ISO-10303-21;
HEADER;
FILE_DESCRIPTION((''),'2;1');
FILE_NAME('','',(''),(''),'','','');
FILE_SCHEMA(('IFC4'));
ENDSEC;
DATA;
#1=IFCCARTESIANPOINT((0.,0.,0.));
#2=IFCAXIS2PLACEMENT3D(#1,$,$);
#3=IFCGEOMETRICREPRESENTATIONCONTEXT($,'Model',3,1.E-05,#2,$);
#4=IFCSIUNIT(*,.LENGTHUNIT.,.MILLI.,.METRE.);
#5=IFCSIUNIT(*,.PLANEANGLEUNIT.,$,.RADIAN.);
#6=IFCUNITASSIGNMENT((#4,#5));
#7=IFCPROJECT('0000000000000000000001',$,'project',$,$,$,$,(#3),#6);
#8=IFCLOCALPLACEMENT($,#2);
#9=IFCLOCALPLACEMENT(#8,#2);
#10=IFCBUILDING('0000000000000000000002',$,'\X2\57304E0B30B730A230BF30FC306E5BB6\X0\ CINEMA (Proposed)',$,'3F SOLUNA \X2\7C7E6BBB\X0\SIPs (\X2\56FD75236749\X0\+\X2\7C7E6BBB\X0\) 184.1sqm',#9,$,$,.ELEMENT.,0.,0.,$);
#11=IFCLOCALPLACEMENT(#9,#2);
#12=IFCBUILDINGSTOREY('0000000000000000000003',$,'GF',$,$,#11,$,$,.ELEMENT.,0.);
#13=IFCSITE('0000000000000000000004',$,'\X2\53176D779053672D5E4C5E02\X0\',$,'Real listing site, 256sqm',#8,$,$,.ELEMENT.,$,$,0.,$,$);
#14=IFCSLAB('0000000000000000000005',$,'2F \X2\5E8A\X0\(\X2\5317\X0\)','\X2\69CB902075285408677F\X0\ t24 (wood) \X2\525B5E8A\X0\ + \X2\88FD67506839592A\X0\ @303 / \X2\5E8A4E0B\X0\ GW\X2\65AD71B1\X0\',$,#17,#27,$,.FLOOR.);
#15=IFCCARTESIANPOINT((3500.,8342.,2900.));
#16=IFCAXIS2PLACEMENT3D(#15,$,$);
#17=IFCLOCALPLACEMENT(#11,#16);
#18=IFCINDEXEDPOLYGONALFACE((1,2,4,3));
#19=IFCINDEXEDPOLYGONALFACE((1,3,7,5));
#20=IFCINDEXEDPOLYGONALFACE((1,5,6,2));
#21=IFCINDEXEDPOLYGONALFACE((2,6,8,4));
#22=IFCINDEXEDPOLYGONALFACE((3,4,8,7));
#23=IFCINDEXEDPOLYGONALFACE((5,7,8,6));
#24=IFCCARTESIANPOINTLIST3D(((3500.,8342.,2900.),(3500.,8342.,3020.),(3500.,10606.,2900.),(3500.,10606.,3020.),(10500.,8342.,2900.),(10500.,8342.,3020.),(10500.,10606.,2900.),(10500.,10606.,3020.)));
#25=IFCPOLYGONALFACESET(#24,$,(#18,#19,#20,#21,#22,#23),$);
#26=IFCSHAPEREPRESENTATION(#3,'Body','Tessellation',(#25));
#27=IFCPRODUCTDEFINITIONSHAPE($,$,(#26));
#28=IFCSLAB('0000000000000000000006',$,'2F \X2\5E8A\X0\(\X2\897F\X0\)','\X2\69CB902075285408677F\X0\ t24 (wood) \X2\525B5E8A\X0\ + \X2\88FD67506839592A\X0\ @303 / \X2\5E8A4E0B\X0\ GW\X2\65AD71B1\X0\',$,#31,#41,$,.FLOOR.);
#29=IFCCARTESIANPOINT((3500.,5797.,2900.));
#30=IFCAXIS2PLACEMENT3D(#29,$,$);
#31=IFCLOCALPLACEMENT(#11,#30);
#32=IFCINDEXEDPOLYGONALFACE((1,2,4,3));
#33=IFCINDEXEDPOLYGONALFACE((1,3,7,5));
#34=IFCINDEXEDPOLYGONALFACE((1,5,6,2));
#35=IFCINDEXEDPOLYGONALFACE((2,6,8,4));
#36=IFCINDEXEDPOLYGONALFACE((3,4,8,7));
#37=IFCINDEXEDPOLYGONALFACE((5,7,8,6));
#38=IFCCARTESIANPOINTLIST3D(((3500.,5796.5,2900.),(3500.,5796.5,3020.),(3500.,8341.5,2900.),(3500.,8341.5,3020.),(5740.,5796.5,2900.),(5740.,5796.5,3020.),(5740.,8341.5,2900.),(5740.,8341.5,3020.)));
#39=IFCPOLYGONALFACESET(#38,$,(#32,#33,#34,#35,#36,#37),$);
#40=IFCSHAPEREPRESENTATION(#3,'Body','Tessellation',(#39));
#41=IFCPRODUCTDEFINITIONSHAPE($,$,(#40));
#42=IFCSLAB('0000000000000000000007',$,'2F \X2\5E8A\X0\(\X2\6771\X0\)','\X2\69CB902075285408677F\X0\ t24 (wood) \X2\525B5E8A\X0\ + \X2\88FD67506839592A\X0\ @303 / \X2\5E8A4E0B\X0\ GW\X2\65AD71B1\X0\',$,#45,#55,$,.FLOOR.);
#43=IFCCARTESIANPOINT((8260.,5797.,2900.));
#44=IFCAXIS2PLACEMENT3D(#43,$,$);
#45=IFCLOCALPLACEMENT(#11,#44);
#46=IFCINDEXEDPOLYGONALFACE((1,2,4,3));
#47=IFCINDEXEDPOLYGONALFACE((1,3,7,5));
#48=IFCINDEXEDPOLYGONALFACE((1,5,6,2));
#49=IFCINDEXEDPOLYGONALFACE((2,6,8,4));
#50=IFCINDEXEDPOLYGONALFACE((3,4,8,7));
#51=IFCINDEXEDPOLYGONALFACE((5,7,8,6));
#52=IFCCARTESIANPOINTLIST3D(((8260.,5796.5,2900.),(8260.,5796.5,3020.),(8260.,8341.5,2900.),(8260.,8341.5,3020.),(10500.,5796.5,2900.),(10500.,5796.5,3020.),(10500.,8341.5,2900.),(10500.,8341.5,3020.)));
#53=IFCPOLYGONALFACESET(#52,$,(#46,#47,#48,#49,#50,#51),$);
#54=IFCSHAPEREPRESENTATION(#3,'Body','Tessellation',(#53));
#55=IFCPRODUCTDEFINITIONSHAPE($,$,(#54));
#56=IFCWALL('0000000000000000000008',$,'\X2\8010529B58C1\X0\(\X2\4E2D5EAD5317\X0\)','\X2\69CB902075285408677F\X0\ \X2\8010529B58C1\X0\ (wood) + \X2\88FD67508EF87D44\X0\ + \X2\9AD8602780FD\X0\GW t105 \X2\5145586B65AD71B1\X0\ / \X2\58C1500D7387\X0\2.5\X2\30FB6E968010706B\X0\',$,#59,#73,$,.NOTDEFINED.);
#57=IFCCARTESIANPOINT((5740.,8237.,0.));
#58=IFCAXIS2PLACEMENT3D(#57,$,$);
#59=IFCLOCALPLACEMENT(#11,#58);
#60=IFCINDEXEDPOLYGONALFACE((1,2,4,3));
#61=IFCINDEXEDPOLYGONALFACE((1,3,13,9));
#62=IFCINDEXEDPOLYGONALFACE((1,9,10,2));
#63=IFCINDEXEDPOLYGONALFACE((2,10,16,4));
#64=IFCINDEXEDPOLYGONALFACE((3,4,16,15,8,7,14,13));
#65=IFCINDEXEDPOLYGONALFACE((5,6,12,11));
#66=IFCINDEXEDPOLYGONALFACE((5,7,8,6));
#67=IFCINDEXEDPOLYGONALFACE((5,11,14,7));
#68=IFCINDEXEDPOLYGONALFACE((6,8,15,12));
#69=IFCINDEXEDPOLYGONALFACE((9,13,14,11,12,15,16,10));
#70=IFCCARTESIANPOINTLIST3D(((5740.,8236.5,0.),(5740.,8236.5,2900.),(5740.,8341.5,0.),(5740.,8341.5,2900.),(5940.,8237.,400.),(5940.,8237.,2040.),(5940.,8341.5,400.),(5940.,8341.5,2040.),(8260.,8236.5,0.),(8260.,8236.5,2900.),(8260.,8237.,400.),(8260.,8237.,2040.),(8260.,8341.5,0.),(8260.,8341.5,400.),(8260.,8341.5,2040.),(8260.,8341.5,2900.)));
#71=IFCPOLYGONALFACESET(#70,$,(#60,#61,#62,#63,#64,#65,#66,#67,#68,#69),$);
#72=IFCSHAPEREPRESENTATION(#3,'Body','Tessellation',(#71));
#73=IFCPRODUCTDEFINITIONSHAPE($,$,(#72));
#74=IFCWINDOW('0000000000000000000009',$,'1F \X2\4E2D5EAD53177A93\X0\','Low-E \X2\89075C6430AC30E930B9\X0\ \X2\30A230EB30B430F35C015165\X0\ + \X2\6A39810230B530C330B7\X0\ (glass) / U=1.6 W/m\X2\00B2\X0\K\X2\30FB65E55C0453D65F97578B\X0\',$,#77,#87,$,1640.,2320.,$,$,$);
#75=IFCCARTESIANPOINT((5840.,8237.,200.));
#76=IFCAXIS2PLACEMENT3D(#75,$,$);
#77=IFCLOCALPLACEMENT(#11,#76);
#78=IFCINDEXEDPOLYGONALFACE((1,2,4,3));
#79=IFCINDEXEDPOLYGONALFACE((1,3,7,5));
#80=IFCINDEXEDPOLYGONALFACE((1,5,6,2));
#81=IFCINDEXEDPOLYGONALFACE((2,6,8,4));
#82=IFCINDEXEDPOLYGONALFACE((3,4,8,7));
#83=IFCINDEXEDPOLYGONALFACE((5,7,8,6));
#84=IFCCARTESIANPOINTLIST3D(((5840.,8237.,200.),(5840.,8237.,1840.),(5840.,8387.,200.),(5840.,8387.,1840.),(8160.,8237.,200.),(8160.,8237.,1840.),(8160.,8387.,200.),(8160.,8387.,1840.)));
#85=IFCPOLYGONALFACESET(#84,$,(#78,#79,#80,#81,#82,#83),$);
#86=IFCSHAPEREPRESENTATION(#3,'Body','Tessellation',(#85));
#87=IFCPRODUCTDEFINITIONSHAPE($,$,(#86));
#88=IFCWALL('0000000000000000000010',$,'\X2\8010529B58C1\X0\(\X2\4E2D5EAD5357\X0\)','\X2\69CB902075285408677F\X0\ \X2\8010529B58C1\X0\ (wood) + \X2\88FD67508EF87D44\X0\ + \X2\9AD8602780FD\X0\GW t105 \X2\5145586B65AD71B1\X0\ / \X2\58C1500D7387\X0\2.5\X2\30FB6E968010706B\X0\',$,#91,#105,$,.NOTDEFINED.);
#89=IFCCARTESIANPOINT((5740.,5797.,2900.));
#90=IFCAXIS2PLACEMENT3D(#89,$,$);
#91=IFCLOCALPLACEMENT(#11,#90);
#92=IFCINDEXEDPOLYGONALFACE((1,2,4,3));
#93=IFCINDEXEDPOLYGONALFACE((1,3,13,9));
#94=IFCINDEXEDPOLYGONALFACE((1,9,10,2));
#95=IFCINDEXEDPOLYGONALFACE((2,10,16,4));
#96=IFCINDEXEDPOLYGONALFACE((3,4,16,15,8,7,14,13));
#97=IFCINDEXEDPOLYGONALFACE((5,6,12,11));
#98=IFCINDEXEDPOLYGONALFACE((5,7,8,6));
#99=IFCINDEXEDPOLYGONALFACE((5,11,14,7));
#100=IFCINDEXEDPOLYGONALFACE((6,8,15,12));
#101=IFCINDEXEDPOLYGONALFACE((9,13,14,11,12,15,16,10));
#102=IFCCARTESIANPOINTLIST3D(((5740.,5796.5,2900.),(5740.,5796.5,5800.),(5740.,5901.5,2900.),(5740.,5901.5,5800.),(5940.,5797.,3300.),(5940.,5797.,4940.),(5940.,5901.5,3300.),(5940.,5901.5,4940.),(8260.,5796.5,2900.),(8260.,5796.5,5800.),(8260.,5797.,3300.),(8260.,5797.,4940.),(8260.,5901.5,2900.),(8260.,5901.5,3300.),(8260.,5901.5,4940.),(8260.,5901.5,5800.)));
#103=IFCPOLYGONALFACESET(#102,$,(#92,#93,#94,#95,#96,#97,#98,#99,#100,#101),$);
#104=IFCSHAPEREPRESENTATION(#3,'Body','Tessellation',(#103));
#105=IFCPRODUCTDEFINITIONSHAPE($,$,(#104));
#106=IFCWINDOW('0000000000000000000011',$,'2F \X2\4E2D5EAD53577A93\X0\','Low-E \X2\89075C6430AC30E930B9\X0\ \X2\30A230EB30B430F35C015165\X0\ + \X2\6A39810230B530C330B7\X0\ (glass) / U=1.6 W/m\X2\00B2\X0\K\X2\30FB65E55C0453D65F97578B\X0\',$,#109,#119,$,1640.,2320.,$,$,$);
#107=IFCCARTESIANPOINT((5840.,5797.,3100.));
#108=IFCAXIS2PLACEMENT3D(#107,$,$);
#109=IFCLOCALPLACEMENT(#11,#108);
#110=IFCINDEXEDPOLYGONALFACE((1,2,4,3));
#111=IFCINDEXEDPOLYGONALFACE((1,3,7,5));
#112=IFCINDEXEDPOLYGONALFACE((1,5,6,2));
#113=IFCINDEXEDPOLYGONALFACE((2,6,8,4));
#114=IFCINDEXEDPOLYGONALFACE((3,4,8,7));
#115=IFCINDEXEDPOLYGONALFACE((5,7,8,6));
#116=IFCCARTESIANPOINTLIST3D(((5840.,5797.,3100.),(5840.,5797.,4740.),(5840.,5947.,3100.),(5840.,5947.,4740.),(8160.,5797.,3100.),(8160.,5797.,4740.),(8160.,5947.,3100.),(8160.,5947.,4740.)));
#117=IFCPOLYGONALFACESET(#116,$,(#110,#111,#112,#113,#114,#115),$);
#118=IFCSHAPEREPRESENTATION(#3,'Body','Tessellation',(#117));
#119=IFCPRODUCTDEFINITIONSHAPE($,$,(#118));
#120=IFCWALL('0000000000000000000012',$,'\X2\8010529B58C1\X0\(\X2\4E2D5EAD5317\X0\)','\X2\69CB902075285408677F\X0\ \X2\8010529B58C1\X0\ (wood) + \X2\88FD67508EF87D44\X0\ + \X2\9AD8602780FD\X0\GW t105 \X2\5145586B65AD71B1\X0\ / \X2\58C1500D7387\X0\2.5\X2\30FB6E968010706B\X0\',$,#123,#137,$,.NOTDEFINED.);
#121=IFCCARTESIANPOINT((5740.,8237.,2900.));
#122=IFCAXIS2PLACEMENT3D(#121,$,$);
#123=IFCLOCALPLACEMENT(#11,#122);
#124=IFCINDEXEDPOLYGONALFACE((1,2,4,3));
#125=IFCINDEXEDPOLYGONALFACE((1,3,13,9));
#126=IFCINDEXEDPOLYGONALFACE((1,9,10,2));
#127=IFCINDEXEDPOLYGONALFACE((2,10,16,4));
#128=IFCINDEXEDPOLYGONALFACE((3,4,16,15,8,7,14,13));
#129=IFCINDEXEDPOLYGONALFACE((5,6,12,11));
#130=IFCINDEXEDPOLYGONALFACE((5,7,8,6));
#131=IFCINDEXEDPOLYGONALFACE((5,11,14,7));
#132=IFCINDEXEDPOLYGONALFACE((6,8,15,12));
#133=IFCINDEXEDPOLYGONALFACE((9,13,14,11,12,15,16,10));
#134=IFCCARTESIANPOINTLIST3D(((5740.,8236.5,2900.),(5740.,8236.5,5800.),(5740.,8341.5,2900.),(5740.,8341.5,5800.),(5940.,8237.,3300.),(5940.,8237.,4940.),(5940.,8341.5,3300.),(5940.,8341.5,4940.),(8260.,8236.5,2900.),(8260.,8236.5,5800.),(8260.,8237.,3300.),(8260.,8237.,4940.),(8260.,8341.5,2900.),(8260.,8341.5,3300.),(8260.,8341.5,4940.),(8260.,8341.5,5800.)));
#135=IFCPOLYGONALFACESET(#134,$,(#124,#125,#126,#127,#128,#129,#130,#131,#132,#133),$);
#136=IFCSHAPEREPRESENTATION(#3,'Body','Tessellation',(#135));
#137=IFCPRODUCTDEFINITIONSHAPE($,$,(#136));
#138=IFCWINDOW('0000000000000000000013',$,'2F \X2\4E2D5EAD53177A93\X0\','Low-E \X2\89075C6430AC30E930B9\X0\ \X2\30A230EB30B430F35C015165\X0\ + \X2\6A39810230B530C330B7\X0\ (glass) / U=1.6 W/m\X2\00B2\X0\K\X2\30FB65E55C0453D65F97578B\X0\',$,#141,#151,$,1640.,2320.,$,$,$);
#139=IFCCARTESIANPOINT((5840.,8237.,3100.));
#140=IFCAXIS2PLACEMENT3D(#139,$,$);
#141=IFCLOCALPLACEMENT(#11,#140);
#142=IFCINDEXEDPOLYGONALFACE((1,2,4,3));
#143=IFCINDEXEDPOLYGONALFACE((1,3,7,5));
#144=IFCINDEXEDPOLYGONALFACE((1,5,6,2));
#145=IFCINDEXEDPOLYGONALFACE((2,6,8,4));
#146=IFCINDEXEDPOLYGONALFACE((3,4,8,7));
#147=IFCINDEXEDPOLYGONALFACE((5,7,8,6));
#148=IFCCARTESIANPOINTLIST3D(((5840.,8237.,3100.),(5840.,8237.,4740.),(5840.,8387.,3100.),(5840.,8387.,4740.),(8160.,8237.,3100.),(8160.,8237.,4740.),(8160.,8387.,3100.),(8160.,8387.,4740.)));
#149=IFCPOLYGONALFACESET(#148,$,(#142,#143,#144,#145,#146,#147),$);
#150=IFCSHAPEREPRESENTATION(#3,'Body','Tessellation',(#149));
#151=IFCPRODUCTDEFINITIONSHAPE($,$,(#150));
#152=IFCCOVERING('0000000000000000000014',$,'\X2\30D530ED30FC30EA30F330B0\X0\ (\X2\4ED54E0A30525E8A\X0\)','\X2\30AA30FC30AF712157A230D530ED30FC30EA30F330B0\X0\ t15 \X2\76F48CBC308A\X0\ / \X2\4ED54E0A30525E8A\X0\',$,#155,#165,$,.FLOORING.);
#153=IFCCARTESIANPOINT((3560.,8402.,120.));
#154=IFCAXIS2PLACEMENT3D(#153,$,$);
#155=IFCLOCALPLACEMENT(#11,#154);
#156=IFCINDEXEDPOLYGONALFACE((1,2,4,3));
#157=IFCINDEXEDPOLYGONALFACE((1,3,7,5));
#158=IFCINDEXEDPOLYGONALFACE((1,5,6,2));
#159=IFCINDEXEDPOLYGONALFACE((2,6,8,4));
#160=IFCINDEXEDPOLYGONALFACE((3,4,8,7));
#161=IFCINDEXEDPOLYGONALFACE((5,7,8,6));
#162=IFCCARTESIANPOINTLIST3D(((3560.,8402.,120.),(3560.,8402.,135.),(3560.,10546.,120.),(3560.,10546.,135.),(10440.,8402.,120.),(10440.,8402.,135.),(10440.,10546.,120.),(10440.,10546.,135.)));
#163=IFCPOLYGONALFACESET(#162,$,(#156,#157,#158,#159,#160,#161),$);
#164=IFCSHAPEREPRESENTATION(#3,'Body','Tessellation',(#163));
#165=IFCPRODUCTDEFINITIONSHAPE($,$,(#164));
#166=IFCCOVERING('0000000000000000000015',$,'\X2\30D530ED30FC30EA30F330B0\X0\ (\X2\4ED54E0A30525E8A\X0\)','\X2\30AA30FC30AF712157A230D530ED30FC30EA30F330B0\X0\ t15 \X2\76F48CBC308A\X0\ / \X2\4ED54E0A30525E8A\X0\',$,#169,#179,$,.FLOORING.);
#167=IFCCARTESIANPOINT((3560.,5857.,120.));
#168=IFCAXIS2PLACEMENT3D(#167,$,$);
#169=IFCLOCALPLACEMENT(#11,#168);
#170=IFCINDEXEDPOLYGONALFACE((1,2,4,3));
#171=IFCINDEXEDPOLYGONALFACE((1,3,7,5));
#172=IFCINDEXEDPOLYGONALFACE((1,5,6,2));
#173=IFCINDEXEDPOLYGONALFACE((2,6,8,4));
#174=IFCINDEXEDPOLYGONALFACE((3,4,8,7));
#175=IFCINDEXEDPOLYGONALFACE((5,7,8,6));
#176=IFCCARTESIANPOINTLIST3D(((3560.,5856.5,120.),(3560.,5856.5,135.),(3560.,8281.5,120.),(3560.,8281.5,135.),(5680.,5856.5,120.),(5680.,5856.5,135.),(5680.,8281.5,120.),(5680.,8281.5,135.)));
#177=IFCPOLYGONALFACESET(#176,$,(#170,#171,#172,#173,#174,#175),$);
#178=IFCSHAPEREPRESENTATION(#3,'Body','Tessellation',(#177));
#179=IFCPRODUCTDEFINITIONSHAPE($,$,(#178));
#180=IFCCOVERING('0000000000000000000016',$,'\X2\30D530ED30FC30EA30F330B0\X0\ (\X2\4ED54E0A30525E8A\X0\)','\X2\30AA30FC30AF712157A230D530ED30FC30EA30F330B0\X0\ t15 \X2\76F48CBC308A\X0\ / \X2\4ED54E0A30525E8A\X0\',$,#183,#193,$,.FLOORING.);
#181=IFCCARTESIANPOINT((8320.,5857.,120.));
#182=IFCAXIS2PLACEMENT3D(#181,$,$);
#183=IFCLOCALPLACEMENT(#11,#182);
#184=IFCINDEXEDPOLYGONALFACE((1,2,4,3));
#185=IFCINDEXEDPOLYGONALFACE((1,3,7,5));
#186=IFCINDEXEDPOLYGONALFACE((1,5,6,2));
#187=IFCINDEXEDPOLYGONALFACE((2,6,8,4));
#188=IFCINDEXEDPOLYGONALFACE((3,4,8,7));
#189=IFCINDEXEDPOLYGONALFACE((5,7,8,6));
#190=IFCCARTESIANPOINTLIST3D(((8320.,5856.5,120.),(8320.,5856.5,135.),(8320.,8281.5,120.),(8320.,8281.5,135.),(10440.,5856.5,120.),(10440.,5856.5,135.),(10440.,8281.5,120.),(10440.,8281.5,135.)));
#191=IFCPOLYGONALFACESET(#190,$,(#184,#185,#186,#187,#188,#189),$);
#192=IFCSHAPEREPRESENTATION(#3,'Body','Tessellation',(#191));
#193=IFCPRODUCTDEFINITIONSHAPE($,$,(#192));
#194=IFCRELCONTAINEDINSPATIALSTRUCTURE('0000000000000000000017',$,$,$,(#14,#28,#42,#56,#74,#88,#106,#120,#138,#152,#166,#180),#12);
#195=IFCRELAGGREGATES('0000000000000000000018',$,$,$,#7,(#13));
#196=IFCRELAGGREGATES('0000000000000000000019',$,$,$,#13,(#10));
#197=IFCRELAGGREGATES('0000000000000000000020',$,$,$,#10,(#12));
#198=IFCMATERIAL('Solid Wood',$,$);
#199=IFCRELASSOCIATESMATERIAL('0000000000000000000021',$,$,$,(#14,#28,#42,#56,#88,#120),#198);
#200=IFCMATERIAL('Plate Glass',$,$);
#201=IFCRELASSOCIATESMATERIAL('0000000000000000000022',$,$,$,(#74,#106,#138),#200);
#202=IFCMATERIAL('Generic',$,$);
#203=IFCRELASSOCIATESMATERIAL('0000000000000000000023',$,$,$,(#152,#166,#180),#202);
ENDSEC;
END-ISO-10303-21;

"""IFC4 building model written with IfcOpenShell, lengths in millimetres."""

from ifc_helpers import new_model, si_unit, frame, frame_2d, origin, place, context, project, spatial, rectangle, extrude, material, element, fill, save


model = new_model("IFC4")

# Units and contexts
model_context = context("Model", 3, precision=1e-05, world=origin())
ifc_project = project(units=[si_unit("LENGTHUNIT", "METRE", prefix="MILLI"), si_unit("PLANEANGLEUNIT", "RADIAN")], contexts=[model_context])

# Site, building, storey
site_placement = place(None, origin())
site = spatial("IfcSite", under=ifc_project, at=site_placement, Name="北海道札幌市", ObjectType="Real listing site, 256sqm", CompositionType="ELEMENT", RefElevation=0.0)
building_placement = place(site_placement, origin())
building = spatial("IfcBuilding", under=site, at=building_placement, Name="地下シアターの家 CINEMA (Proposed)", ObjectType="3F SOLUNA 籾殻SIPs (国産杉+籾殻) 184.1sqm", CompositionType="ELEMENT", ElevationOfRefHeight=0.0, ElevationOfTerrain=0.0)
storey_placement = place(building_placement, origin())
storey = spatial("IfcBuildingStorey", under=building, at=storey_placement, Name="GF", CompositionType="ELEMENT", Elevation=0.0)

# Slabs
ifc_material_1 = material(Name="Solid Wood")
slab_1_placement = place(storey_placement, frame((3500.0, 8342.0, 2900.0)))
element("IfcSlab", 1, at=slab_1_placement, inside=storey, material=ifc_material_1, Name="2F 床(北)", Description="構造用合板 t24 (wood) 剛床 + 製材根太 @303 / 床下 GW断熱", PredefinedType="FLOOR", context=model_context, shape_type="SweptSolid", body=[
    extrude(rectangle(XDim=7000.0, YDim=2264.0, at=frame_2d((3500.0, 1132.0))), frame((3500.0, 8342.0, 2900.0)), (0.0, 0.0, 1.0), 120.0),
])
slab_2_placement = place(storey_placement, frame((3500.0, 5797.0, 2900.0)))
element("IfcSlab", 2, at=slab_2_placement, inside=storey, material=ifc_material_1, Name="2F 床(西)", Description="構造用合板 t24 (wood) 剛床 + 製材根太 @303 / 床下 GW断熱", PredefinedType="FLOOR", context=model_context, shape_type="SweptSolid", body=[
    extrude(rectangle(XDim=2240.0, YDim=2545.0, at=frame_2d((1120.0, 1272.0))), frame((3500.0, 5797.0, 2900.0)), (0.0, 0.0, 1.0), 120.0),
])
slab_3_placement = place(storey_placement, frame((8260.0, 5797.0, 2900.0)))
element("IfcSlab", 3, at=slab_3_placement, inside=storey, material=ifc_material_1, Name="2F 床(東)", Description="構造用合板 t24 (wood) 剛床 + 製材根太 @303 / 床下 GW断熱", PredefinedType="FLOOR", context=model_context, shape_type="SweptSolid", body=[
    extrude(rectangle(XDim=2240.0, YDim=2545.0, at=frame_2d((1120.0, 1272.0))), frame((8260.0, 5797.0, 2900.0)), (0.0, 0.0, 1.0), 120.0),
])

# Wall, opening, window
wall_1_placement = place(storey_placement, frame((5740.0, 8237.0, 0.0)))
wall_1 = element("IfcWall", 4, at=wall_1_placement, inside=storey, material=ifc_material_1, Name="耐力壁(中庭北)", Description="構造用合板 耐力壁 (wood) + 製材軸組 + 高性能GW t105 充填断熱 / 壁倍率2.5・準耐火", PredefinedType="NOTDEFINED", context=model_context, shape_type="SweptSolid", body=[
    extrude(rectangle(XDim=2520.0, YDim=105.0, at=frame_2d((1260.0, 52.0))), frame((5740.0, 8237.0, 0.0)), (0.0, 0.0, 1.0), 2900.0),
])
opening_1_placement = place(storey_placement, frame((5840.0, 8237.0, 200.0)))
opening_1 = element("IfcOpeningElement", 5, at=opening_1_placement, cuts=wall_1, PredefinedType="NOTDEFINED", context=model_context, shape_type="SweptSolid", body=[
    extrude(rectangle(XDim=2320.0, YDim=150.0, at=frame_2d((1160.0, 75.0))), frame((5840.0, 8237.0, 200.0)), (0.0, 0.0, 1.0), 1640.0),
])
ifc_material_2 = material(Name="Plate Glass")
window_1_placement = place(storey_placement, frame((5840.0, 8237.0, 200.0)))
window_1 = element("IfcWindow", 6, at=window_1_placement, inside=storey, material=ifc_material_2, Name="1F 中庭北窓", Description="Low-E 複層ガラス アルゴン封入 + 樹脂サッシ (glass) / U=1.6 W/m²K・日射取得型", OverallHeight=1640.0, OverallWidth=2320.0, context=model_context, shape_type="SweptSolid", body=[
    extrude(rectangle(XDim=2320.0, YDim=150.0, at=frame_2d((1160.0, 75.0))), frame((5840.0, 8237.0, 200.0)), (0.0, 0.0, 1.0), 1640.0),
])
fill(opening_1, window_1)

# Walls, openings, windows
wall_2_placement = place(storey_placement, frame((5740.0, 5797.0, 2900.0)))
wall_2 = element("IfcWall", 7, at=wall_2_placement, inside=storey, material=ifc_material_1, Name="耐力壁(中庭南)", Description="構造用合板 耐力壁 (wood) + 製材軸組 + 高性能GW t105 充填断熱 / 壁倍率2.5・準耐火", PredefinedType="NOTDEFINED", context=model_context, shape_type="SweptSolid", body=[
    extrude(rectangle(XDim=2520.0, YDim=105.0, at=frame_2d((1260.0, 52.0))), frame((5740.0, 5797.0, 2900.0)), (0.0, 0.0, 1.0), 2900.0),
])
opening_2_placement = place(storey_placement, frame((5840.0, 5797.0, 3100.0)))
opening_2 = element("IfcOpeningElement", 8, at=opening_2_placement, cuts=wall_2, PredefinedType="NOTDEFINED", context=model_context, shape_type="SweptSolid", body=[
    extrude(rectangle(XDim=2320.0, YDim=150.0, at=frame_2d((1160.0, 75.0))), frame((5840.0, 5797.0, 3100.0)), (0.0, 0.0, 1.0), 1640.0),
])
window_2_placement = place(storey_placement, frame((5840.0, 5797.0, 3100.0)))
window_2 = element("IfcWindow", 9, at=window_2_placement, inside=storey, material=ifc_material_2, Name="2F 中庭南窓", Description="Low-E 複層ガラス アルゴン封入 + 樹脂サッシ (glass) / U=1.6 W/m²K・日射取得型", OverallHeight=1640.0, OverallWidth=2320.0, context=model_context, shape_type="SweptSolid", body=[
    extrude(rectangle(XDim=2320.0, YDim=150.0, at=frame_2d((1160.0, 75.0))), frame((5840.0, 5797.0, 3100.0)), (0.0, 0.0, 1.0), 1640.0),
])
fill(opening_2, window_2)
wall_3_placement = place(storey_placement, frame((5740.0, 8237.0, 2900.0)))
wall_3 = element("IfcWall", 10, at=wall_3_placement, inside=storey, material=ifc_material_1, Name="耐力壁(中庭北)", Description="構造用合板 耐力壁 (wood) + 製材軸組 + 高性能GW t105 充填断熱 / 壁倍率2.5・準耐火", PredefinedType="NOTDEFINED", context=model_context, shape_type="SweptSolid", body=[
    extrude(rectangle(XDim=2520.0, YDim=105.0, at=frame_2d((1260.0, 52.0))), frame((5740.0, 8237.0, 2900.0)), (0.0, 0.0, 1.0), 2900.0),
])
opening_3_placement = place(storey_placement, frame((5840.0, 8237.0, 3100.0)))
opening_3 = element("IfcOpeningElement", 11, at=opening_3_placement, cuts=wall_3, PredefinedType="NOTDEFINED", context=model_context, shape_type="SweptSolid", body=[
    extrude(rectangle(XDim=2320.0, YDim=150.0, at=frame_2d((1160.0, 75.0))), frame((5840.0, 8237.0, 3100.0)), (0.0, 0.0, 1.0), 1640.0),
])
window_3_placement = place(storey_placement, frame((5840.0, 8237.0, 3100.0)))
window_3 = element("IfcWindow", 12, at=window_3_placement, inside=storey, material=ifc_material_2, Name="2F 中庭北窓", Description="Low-E 複層ガラス アルゴン封入 + 樹脂サッシ (glass) / U=1.6 W/m²K・日射取得型", OverallHeight=1640.0, OverallWidth=2320.0, context=model_context, shape_type="SweptSolid", body=[
    extrude(rectangle(XDim=2320.0, YDim=150.0, at=frame_2d((1160.0, 75.0))), frame((5840.0, 8237.0, 3100.0)), (0.0, 0.0, 1.0), 1640.0),
])
fill(opening_3, window_3)

# Coverings
ifc_material_3 = material(Name="Generic")
covering_1_placement = place(storey_placement, frame((3560.0, 8402.0, 120.0)))
element("IfcCovering", 13, at=covering_1_placement, inside=storey, material=ifc_material_3, Name="フローリング (仕上げ床)", Description="オーク無垢フローリング t15 直貼り / 仕上げ床", PredefinedType="FLOORING", context=model_context, shape_type="SweptSolid", body=[
    extrude(rectangle(XDim=6880.0, YDim=2144.0, at=frame_2d((3440.0, 1072.0))), frame((3560.0, 8402.0, 120.0)), (0.0, 0.0, 1.0), 15.0),
])
covering_2_placement = place(storey_placement, frame((3560.0, 5857.0, 120.0)))
element("IfcCovering", 14, at=covering_2_placement, inside=storey, material=ifc_material_3, Name="フローリング (仕上げ床)", Description="オーク無垢フローリング t15 直貼り / 仕上げ床", PredefinedType="FLOORING", context=model_context, shape_type="SweptSolid", body=[
    extrude(rectangle(XDim=2120.0, YDim=2425.0, at=frame_2d((1060.0, 1212.0))), frame((3560.0, 5857.0, 120.0)), (0.0, 0.0, 1.0), 15.0),
])
covering_3_placement = place(storey_placement, frame((8320.0, 5857.0, 120.0)))
element("IfcCovering", 15, at=covering_3_placement, inside=storey, material=ifc_material_3, Name="フローリング (仕上げ床)", Description="オーク無垢フローリング t15 直貼り / 仕上げ床", PredefinedType="FLOORING", context=model_context, shape_type="SweptSolid", body=[
    extrude(rectangle(XDim=2120.0, YDim=2425.0, at=frame_2d((1060.0, 1212.0))), frame((8320.0, 5857.0, 120.0)), (0.0, 0.0, 1.0), 15.0),
])

save(model, "model.ifc")
